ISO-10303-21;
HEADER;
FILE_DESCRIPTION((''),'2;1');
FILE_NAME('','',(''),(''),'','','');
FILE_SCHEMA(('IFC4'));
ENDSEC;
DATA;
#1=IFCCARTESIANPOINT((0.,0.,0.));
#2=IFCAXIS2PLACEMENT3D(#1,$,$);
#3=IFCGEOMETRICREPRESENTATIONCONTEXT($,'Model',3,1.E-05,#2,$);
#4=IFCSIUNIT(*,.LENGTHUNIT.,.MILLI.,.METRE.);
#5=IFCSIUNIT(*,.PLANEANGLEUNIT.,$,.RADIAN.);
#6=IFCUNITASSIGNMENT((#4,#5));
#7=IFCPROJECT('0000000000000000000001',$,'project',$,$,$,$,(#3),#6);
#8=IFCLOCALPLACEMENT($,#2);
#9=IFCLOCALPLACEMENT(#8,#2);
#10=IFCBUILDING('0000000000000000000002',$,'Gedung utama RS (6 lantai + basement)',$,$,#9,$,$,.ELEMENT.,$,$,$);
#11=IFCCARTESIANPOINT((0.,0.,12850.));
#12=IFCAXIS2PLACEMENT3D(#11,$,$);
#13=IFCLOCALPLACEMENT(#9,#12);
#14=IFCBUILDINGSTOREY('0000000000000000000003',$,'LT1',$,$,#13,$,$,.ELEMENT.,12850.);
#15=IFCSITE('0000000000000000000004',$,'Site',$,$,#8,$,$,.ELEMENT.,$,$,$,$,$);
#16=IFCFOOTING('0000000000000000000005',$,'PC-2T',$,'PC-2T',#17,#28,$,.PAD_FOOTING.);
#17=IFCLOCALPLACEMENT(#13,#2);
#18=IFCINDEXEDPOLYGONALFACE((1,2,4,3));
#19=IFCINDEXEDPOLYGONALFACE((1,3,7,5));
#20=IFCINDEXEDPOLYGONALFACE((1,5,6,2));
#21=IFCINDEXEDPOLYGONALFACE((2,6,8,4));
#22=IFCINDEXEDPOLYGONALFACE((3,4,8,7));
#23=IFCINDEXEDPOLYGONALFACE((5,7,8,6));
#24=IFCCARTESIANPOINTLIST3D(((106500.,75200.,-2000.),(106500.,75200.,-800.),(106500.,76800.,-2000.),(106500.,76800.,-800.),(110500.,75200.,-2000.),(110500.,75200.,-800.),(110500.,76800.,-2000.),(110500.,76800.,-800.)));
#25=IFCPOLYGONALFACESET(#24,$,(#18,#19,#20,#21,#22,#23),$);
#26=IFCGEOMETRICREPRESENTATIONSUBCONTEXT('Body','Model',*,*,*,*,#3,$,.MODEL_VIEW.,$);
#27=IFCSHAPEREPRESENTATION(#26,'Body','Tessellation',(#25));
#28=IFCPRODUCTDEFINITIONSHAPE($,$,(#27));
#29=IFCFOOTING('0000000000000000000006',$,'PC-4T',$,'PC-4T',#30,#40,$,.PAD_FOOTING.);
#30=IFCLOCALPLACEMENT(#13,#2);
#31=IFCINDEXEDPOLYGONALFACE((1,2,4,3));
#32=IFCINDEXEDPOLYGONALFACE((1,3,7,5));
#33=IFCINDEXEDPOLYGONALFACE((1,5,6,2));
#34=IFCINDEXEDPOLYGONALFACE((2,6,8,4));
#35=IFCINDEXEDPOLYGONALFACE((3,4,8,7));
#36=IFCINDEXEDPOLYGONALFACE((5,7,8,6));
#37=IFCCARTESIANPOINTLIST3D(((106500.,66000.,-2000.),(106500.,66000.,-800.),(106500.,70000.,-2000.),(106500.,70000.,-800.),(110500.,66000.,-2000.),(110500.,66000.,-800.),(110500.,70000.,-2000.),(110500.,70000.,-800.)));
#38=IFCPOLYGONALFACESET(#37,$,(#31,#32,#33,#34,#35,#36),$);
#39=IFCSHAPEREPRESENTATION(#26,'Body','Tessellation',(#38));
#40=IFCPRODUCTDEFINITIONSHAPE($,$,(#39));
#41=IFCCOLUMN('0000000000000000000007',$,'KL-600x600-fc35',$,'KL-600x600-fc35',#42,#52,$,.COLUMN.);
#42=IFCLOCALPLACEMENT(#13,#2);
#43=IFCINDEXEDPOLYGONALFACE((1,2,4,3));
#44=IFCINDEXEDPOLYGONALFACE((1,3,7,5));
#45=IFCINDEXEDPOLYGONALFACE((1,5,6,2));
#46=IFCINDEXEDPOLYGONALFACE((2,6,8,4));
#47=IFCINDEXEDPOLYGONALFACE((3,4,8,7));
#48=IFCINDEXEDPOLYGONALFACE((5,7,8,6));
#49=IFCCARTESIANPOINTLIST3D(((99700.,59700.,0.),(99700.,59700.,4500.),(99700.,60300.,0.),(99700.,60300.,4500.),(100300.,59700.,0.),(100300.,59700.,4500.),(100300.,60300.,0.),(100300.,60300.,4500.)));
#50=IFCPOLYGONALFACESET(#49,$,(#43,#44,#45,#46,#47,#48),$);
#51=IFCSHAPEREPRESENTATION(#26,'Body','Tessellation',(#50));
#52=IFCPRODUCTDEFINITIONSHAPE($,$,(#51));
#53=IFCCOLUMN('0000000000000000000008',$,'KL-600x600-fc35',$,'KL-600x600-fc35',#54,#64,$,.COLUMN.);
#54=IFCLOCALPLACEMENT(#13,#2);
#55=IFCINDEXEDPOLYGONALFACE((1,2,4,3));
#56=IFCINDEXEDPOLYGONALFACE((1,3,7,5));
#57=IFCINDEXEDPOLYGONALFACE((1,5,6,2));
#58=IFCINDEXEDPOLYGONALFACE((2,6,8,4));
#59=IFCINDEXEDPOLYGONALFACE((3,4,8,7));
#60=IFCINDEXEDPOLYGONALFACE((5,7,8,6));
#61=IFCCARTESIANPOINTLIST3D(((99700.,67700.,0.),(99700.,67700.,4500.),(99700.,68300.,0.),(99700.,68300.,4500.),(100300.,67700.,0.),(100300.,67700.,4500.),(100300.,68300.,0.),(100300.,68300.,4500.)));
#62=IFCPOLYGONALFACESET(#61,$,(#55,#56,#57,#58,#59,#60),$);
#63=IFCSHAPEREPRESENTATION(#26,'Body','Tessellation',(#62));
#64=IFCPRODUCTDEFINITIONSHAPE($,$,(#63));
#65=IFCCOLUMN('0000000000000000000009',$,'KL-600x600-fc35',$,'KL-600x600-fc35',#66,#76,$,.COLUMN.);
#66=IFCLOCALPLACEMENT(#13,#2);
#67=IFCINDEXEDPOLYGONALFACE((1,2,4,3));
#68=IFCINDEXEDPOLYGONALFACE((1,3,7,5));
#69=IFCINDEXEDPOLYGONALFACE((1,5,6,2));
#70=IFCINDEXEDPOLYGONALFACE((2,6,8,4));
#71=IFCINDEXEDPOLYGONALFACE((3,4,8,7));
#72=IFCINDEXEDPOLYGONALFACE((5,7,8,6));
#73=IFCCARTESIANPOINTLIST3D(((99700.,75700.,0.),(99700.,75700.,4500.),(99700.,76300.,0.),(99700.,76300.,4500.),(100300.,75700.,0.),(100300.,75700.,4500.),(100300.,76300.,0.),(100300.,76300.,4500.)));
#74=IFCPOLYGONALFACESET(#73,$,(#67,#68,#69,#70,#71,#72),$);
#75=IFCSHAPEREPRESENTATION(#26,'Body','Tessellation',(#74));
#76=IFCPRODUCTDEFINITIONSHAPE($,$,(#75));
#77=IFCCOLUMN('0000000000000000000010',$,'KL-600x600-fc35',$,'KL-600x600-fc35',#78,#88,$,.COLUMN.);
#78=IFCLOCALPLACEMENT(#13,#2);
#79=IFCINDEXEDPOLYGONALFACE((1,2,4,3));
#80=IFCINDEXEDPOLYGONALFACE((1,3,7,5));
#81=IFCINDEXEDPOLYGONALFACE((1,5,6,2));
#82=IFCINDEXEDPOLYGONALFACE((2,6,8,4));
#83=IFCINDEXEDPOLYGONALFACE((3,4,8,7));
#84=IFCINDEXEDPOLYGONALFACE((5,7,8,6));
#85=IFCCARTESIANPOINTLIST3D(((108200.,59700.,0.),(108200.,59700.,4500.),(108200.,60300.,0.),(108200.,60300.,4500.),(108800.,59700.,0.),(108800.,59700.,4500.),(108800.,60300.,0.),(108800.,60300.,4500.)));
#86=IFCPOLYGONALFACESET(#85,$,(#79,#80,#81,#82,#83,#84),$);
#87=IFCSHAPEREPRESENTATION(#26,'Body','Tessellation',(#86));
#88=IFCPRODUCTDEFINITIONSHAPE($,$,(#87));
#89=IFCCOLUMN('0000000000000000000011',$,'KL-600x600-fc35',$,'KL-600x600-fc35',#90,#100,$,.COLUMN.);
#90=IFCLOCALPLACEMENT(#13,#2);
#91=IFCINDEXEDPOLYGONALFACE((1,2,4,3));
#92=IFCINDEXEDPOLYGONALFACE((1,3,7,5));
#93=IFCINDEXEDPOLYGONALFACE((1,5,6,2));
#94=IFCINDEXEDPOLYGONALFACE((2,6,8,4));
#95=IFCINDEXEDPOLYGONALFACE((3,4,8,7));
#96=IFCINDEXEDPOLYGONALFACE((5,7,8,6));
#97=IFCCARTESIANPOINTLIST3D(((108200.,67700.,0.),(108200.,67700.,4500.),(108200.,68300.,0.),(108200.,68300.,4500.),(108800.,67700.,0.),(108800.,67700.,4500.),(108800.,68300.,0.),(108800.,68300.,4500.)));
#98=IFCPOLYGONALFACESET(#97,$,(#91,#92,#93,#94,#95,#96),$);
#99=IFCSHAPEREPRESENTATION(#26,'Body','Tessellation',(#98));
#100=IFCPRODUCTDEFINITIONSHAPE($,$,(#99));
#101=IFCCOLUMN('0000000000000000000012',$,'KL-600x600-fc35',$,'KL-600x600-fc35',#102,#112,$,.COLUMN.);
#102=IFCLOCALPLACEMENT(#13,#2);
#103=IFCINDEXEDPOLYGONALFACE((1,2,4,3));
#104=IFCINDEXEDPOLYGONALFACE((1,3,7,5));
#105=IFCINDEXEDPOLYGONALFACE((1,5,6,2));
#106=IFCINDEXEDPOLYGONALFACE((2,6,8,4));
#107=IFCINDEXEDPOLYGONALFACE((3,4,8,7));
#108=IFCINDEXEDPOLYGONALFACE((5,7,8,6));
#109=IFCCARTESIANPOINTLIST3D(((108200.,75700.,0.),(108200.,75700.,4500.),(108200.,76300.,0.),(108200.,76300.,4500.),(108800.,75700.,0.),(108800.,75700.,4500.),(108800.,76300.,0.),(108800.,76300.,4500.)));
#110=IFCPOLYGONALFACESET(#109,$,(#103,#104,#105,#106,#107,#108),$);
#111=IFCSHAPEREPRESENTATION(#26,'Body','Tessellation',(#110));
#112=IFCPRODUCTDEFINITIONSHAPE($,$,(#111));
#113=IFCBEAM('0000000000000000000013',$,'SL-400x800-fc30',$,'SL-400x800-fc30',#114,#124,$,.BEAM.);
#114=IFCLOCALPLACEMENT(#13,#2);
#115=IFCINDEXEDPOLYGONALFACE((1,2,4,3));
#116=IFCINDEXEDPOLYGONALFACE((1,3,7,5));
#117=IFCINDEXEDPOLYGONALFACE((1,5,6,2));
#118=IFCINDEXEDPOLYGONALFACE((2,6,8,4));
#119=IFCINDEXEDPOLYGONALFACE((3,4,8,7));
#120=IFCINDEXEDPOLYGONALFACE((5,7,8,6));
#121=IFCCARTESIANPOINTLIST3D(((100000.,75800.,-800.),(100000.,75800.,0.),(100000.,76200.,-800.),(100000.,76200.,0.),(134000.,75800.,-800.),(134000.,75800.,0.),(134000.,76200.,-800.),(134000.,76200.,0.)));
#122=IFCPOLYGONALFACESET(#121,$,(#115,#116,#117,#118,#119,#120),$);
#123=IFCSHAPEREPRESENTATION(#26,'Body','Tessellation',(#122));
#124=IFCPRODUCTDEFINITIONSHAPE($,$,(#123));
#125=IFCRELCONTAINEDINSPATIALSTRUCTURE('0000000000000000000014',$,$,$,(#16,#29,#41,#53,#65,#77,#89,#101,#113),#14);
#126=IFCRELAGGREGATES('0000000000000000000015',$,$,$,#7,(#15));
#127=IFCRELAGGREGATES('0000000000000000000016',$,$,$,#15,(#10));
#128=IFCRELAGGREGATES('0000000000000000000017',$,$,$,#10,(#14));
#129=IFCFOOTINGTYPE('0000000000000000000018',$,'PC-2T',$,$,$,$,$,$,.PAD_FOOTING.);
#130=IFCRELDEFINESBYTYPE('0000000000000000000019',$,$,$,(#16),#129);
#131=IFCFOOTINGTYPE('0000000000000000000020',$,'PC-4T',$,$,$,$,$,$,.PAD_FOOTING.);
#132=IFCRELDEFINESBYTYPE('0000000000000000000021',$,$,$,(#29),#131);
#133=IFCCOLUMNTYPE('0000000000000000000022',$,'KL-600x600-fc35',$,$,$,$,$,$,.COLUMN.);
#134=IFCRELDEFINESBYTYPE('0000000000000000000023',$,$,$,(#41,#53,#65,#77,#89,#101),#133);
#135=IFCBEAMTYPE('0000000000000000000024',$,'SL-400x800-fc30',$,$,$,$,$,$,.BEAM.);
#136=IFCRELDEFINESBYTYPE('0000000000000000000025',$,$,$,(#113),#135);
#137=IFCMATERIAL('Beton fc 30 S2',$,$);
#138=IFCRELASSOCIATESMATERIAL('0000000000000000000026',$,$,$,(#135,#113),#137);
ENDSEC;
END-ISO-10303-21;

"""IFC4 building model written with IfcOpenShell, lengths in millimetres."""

from ifc_helpers import new_model, si_unit, frame, origin, origin_2d, place, context, subcontext, project, spatial, rectangle, extrude, material, material_profile, profile_set, profile_usage, type_object, element, save


model = new_model("IFC4")

# Units and contexts
model_context = context("Model", 3, precision=1e-05, world=origin())
body_context = subcontext(model_context, "Body", "Model", "MODEL_VIEW")
ifc_project = project(units=[si_unit("LENGTHUNIT", "METRE", prefix="MILLI"), si_unit("PLANEANGLEUNIT", "RADIAN")], contexts=[model_context])

# Site, building, storey
site_placement = place(None, origin())
site = spatial("IfcSite", under=ifc_project, at=site_placement, Name="Site", CompositionType="ELEMENT")
building_placement = place(site_placement, origin())
building = spatial("IfcBuilding", under=site, at=building_placement, Name="Gedung utama RS (6 lantai + basement)", CompositionType="ELEMENT")
storey_placement = place(building_placement, frame((0.0, 0.0, 12850.0)))
storey = spatial("IfcBuildingStorey", under=building, at=storey_placement, Name="LT1", CompositionType="ELEMENT", Elevation=12850.0)

# Footings
ifc_material_profile_1 = material_profile(None, rectangle(XDim=4000.0, YDim=1600.0, at=origin_2d()), Name="PC-2T")
ifc_profile_set_1 = profile_set([ifc_material_profile_1], Name="PC-2T")
ifc_profile_usage_1 = profile_usage(ifc_profile_set_1, cardinal=5)
footing_type_1 = type_object("IfcFootingType", Name="PC-2T", PredefinedType="PAD_FOOTING", material=ifc_profile_set_1)
footing_1_placement = place(storey_placement, frame((108500.0, 76000.0, -2000.0), z_axis=(0.0, 0.0, 1.0), x_axis=(1.0, 0.0, 0.0)))
element("IfcFooting", 1, at=footing_1_placement, inside=storey, type_object=footing_type_1, material=ifc_profile_usage_1, Name="PC-2T", ObjectType="PC-2T", PredefinedType="PAD_FOOTING", context=body_context, shape_type="SweptSolid", body=[
    extrude(rectangle(XDim=4000.0, YDim=1600.0, at=origin_2d()), origin(), (0.0, 0.0, 1.0), 1200.0),
])
ifc_material_profile_2 = material_profile(None, rectangle(XDim=4000.0, YDim=4000.0, at=origin_2d()), Name="PC-4T")
ifc_profile_set_2 = profile_set([ifc_material_profile_2], Name="PC-4T")
ifc_profile_usage_2 = profile_usage(ifc_profile_set_2, cardinal=5)
footing_type_2 = type_object("IfcFootingType", Name="PC-4T", PredefinedType="PAD_FOOTING", material=ifc_profile_set_2)
footing_2_placement = place(storey_placement, frame((108500.0, 68000.0, -2000.0), z_axis=(0.0, 0.0, 1.0), x_axis=(1.0, 0.0, 0.0)))
element("IfcFooting", 2, at=footing_2_placement, inside=storey, type_object=footing_type_2, material=ifc_profile_usage_2, Name="PC-4T", ObjectType="PC-4T", PredefinedType="PAD_FOOTING", context=body_context, shape_type="SweptSolid", body=[
    extrude(rectangle(XDim=4000.0, YDim=4000.0, at=origin_2d()), origin(), (0.0, 0.0, 1.0), 1200.0),
])

# Columns
ifc_material_profile_3 = material_profile(None, rectangle(XDim=600.0, YDim=600.0, at=origin_2d()), Name="KL-600x600-fc35")
ifc_profile_set_3 = profile_set([ifc_material_profile_3], Name="KL-600x600-fc35")
ifc_profile_usage_3 = profile_usage(ifc_profile_set_3, cardinal=5)
column_type = type_object("IfcColumnType", Name="KL-600x600-fc35", PredefinedType="COLUMN", material=ifc_profile_set_3)
for number, where, z_axis, x_axis, name in (
    (3, (100000.0, 60000.0, 0.0), (0.0, 0.0, 1.0), (1.0, 0.0, 0.0), "KL-600x600-fc35"),
    (4, (100000.0, 68000.0, 0.0), (0.0, 0.0, 1.0), (1.0, 0.0, 0.0), "KL-600x600-fc35"),
    (5, (100000.0, 76000.0, 0.0), (0.0, 0.0, 1.0), (1.0, 0.0, 0.0), "KL-600x600-fc35"),
    (6, (108500.0, 60000.0, 0.0), (0.0, 0.0, 1.0), (1.0, 0.0, 0.0), "KL-600x600-fc35"),
    (7, (108500.0, 68000.0, 0.0), (0.0, 0.0, 1.0), (1.0, 0.0, 0.0), "KL-600x600-fc35"),
    (8, (108500.0, 76000.0, 0.0), (0.0, 0.0, 1.0), (1.0, 0.0, 0.0), "KL-600x600-fc35"),
):
    element("IfcColumn", number, at=place(storey_placement, frame(where, z_axis=z_axis, x_axis=x_axis)), inside=storey, type_object=column_type, material=ifc_profile_usage_3, Name=name, ObjectType="KL-600x600-fc35", PredefinedType="COLUMN", context=body_context, shape_type="SweptSolid", body=[
        extrude(rectangle(XDim=600.0, YDim=600.0, at=origin_2d()), origin(), (0.0, 0.0, 1.0), 4500.0),
    ])

# Beam
ifc_material_1 = material(Name="Beton fc 30 S2")
ifc_material_profile_4 = material_profile(ifc_material_1, rectangle(XDim=400.0, YDim=800.0, at=origin_2d()), Name="SL-400x800-fc30")
ifc_profile_set_4 = profile_set([ifc_material_profile_4], Name="SL-400x800-fc30")
ifc_profile_usage_4 = profile_usage(ifc_profile_set_4, cardinal=8)
beam_type = type_object("IfcBeamType", Name="SL-400x800-fc30", PredefinedType="BEAM", material=ifc_profile_set_4)
beam_placement = place(storey_placement, frame((100000.0, 76000.0, -400.0)))
element("IfcBeam", 9, at=beam_placement, inside=storey, type_object=beam_type, material=ifc_profile_usage_4, Name="SL-400x800-fc30", ObjectType="SL-400x800-fc30", PredefinedType="BEAM", context=body_context, shape_type="SweptSolid", body=[
    extrude(rectangle(XDim=400.0, YDim=800.0, at=origin_2d()), frame((0.0, 0.0, 0.0), z_axis=(1.0, 0.0, 0.0), x_axis=(0.0, 1.0, 0.0)), (0.0, 0.0, 1.0), 34000.0),
])

save(model, "model.ifc")
